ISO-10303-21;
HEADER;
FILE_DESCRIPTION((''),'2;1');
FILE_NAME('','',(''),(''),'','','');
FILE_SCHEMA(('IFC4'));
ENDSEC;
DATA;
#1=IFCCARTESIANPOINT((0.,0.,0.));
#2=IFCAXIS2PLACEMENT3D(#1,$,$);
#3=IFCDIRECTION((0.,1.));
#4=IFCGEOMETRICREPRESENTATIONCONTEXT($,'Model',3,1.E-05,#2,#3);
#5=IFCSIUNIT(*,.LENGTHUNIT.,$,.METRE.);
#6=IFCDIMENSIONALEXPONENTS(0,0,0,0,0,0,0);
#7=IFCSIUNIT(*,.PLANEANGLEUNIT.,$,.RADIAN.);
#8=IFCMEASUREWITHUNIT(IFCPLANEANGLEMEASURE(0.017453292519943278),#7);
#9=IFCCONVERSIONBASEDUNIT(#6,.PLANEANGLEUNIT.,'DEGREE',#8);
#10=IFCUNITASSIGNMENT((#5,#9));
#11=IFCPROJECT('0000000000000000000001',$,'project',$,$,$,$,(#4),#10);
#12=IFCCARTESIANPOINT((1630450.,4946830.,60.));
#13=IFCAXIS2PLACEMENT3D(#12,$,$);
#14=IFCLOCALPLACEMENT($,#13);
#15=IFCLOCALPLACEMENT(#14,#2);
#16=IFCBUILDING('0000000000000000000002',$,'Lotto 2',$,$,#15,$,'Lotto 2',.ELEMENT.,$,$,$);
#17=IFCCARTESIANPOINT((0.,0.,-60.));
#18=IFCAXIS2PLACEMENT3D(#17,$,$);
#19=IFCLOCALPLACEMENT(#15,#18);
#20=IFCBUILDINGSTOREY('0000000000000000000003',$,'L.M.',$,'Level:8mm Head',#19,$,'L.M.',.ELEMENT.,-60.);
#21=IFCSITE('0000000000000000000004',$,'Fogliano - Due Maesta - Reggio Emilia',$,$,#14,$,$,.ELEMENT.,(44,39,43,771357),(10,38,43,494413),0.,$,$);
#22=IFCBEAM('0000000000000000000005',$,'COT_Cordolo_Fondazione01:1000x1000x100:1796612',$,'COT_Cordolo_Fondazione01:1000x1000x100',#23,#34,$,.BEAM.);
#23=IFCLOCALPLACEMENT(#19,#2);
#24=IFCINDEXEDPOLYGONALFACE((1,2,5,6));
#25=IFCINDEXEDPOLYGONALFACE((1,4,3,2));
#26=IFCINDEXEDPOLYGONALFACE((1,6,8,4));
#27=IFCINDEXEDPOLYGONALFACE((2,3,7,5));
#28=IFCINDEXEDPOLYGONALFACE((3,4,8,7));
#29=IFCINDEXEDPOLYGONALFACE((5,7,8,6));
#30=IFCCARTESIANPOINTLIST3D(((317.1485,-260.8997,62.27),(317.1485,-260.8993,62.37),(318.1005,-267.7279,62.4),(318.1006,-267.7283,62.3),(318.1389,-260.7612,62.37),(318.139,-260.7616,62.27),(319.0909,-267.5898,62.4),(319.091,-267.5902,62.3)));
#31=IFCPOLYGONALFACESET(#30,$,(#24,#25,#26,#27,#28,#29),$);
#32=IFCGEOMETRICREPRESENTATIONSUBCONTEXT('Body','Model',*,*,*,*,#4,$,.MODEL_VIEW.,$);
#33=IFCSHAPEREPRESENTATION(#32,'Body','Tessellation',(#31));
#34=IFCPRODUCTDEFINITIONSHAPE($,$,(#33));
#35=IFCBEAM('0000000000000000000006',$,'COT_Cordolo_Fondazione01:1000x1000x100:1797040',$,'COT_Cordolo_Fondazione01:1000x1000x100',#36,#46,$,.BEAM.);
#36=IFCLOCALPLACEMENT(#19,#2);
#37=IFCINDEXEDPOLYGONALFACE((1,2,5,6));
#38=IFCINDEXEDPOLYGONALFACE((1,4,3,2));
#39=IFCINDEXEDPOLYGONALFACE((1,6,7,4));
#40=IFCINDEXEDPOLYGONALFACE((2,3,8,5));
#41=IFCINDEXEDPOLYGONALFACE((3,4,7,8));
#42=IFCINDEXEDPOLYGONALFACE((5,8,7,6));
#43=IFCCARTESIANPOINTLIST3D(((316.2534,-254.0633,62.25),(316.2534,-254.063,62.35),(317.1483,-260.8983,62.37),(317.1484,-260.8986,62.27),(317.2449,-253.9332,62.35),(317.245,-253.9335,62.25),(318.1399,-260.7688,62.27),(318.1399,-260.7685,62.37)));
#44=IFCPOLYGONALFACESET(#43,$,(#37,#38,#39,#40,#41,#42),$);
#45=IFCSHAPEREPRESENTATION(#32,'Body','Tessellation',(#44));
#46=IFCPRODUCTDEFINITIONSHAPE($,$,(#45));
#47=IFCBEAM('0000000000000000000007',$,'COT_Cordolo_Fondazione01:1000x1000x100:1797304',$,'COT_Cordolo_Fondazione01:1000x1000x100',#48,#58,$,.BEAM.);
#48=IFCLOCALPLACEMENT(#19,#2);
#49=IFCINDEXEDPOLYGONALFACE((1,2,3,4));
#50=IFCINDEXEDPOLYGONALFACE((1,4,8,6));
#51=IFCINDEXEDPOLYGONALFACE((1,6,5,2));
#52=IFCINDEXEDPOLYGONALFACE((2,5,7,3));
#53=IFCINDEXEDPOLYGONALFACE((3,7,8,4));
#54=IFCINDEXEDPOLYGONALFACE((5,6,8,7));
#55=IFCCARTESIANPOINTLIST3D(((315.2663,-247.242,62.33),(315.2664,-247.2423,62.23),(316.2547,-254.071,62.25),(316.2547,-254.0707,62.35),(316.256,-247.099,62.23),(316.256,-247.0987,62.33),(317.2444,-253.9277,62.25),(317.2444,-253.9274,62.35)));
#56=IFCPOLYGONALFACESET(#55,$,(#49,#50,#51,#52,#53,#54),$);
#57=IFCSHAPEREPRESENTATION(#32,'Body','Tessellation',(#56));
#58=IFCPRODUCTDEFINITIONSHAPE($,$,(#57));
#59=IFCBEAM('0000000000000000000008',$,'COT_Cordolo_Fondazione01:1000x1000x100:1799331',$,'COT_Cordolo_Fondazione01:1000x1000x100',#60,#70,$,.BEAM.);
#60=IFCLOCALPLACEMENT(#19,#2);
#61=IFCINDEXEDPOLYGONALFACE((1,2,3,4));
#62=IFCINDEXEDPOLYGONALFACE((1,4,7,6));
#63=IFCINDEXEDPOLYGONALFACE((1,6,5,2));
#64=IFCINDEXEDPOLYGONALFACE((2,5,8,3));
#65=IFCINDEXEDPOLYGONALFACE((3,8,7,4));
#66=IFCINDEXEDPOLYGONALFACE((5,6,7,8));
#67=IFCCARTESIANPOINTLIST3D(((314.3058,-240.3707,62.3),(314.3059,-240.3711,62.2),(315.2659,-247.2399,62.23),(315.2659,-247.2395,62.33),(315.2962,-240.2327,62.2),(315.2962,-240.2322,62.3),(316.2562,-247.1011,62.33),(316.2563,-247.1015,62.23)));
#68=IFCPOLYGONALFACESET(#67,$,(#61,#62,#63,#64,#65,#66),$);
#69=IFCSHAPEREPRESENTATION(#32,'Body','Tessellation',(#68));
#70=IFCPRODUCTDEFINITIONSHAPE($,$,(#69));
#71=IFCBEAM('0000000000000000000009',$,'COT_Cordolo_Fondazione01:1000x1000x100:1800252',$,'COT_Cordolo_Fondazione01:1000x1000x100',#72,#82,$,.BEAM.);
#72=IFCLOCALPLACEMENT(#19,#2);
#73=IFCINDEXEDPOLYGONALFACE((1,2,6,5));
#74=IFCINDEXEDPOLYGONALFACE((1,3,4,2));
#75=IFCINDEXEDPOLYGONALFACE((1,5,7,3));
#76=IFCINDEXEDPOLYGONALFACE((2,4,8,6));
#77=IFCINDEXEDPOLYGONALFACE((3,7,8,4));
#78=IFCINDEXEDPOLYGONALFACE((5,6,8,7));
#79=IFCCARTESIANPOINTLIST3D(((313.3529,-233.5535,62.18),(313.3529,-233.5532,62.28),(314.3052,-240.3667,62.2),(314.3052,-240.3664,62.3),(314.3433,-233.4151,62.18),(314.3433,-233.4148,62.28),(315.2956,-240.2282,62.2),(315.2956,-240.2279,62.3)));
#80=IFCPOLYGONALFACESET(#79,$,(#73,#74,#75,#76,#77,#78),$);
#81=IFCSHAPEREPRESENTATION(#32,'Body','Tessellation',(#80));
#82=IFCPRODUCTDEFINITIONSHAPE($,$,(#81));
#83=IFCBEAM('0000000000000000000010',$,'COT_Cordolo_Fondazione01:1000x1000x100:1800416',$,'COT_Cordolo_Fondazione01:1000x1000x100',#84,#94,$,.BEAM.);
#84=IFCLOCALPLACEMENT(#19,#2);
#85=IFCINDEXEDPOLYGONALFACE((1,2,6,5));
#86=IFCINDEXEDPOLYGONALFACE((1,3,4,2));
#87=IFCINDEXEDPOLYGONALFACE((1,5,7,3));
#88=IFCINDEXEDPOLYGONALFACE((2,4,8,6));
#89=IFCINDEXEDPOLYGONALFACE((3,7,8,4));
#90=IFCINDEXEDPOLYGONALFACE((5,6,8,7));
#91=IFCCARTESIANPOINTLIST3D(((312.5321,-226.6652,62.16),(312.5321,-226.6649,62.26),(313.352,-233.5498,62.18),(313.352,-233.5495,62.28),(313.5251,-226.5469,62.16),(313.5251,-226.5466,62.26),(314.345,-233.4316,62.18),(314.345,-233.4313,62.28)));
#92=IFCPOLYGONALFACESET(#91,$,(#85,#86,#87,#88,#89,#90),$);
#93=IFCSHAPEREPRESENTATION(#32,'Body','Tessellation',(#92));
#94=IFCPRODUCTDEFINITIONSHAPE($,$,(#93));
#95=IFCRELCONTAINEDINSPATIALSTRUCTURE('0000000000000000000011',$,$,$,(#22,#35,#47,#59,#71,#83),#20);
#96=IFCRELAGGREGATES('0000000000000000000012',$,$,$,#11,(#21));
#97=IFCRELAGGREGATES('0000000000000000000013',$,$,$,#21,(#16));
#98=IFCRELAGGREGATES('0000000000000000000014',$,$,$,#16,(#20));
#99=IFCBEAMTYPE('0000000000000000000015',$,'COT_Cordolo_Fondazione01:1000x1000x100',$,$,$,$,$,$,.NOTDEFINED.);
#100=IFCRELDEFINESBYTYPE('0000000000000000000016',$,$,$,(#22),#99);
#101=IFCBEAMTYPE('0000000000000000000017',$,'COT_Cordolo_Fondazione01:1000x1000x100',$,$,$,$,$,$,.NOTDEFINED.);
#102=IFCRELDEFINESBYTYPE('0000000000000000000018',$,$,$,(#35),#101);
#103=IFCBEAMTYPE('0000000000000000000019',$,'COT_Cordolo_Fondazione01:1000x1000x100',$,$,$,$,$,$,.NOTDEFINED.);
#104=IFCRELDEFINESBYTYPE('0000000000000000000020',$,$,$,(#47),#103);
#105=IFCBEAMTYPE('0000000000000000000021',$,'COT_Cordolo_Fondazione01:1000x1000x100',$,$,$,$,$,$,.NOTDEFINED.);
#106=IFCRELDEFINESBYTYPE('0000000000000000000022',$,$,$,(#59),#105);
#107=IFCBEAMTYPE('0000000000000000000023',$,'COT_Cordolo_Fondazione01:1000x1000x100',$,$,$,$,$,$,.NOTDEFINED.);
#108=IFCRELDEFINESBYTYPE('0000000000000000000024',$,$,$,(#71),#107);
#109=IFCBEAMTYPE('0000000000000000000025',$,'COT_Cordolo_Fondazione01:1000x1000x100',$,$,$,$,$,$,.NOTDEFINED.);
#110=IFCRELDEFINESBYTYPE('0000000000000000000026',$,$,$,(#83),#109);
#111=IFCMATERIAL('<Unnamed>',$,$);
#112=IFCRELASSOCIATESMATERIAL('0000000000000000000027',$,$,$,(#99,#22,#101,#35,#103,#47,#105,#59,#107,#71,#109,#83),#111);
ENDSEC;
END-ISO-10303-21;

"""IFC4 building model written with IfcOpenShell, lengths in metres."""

from ifc_helpers import new_model, entity, si_unit, converted_unit, direction, frame, origin, place, context, subcontext, project, spatial, indexed_curve, outline, extrude, source, transform, mapped, material, type_object, type_shapes, element, save


model = new_model("IFC4")

# Units and contexts
model_context = context("Model", 3, precision=1e-05, world=origin(), true_north=direction((0.0, 1.0)))
body_context = subcontext(model_context, "Body", "Model", "MODEL_VIEW")
ifc_project = project(units=[si_unit("LENGTHUNIT", "METRE"), converted_unit("PLANEANGLEUNIT", "DEGREE", entity("IfcPlaneAngleMeasure", 0.017453292519943278), si_unit("PLANEANGLEUNIT", "RADIAN"), dimensions=[0, 0, 0, 0, 0, 0, 0])], contexts=[model_context])

# Site, building, storey
site_placement = place(None, frame((1630450.0, 4946830.0, 60.0)))
site = spatial("IfcSite", under=ifc_project, at=site_placement, Name="Fogliano - Due Maesta - Reggio Emilia", CompositionType="ELEMENT", RefLatitude=(44, 39, 43, 771357), RefLongitude=(10, 38, 43, 494413), RefElevation=0.0)
building_placement = place(site_placement, origin())
building = spatial("IfcBuilding", under=site, at=building_placement, Name="Lotto 2", LongName="Lotto 2", CompositionType="ELEMENT")
storey_placement = place(building_placement, frame((0.0, 0.0, -60.0)))
storey = spatial("IfcBuildingStorey", under=building, at=storey_placement, Name="L.M.", ObjectType="Level:8mm Head", LongName="L.M.", CompositionType="ELEMENT", Elevation=-60.0)

# Beams
ifc_material_1 = material(Name="<Unnamed>")
beam_type_1 = type_object("IfcBeamType", Name="COT_Cordolo_Fondazione01:1000x1000x100", PredefinedType="NOTDEFINED", material=ifc_material_1)
shared_shape_1 = source(origin(), body_context, "Body", "SweptSolid", [
    extrude(outline(indexed_curve([(-3.4474, -0.5), (3.4474, -0.5), (3.4474, 0.5), (-3.4474, 0.5), (-3.4474, -0.5)], self_intersect=False)), frame((-0.0019, 0.0, -0.05), z_axis=(0.0, 0.0, 1.0), x_axis=(-1.0, 0.0, 0.0)), (0.0, 0.0, 1.0), 0.1),
])
type_shapes(beam_type_1, [shared_shape_1])
beam_1_placement = place(storey_placement, frame((318.1195, -264.2429, 62.335), z_axis=(-0.000601, 0.004312, 0.999991), x_axis=(-0.138084, 0.990411, -0.004354)))
element("IfcBeam", 1, at=beam_1_placement, inside=storey, type_object=beam_type_1, material=ifc_material_1, Name="COT_Cordolo_Fondazione01:1000x1000x100:1796612", ObjectType="COT_Cordolo_Fondazione01:1000x1000x100", PredefinedType="BEAM", context=body_context, shape_type="MappedRepresentation", body=[
    mapped(shared_shape_1, transform((0.0, 0.0, 0.0), scale=1.0)),
])
beam_type_2 = type_object("IfcBeamType", Name="COT_Cordolo_Fondazione01:1000x1000x100", PredefinedType="NOTDEFINED", material=ifc_material_1)
shared_shape_2 = source(origin(), body_context, "Body", "SweptSolid", [
    extrude(outline(indexed_curve([(-3.4468, -0.5), (3.4468, -0.5), (3.4468, 0.5), (-3.4468, 0.5), (-3.4468, -0.5)], self_intersect=False)), frame((-0.0019, 0.0, -0.05), z_axis=(0.0, 0.0, 1.0), x_axis=(-1.0, 0.0, 0.0)), (0.0, 0.0, 1.0), 0.1),
])
type_shapes(beam_type_2, [shared_shape_2])
beam_2_placement = place(storey_placement, frame((317.1964, -257.4141, 62.31), z_axis=(-0.000377, 0.002878, 0.999996), x_axis=(-0.129819, 0.991533, -0.002903)))
element("IfcBeam", 2, at=beam_2_placement, inside=storey, type_object=beam_type_2, material=ifc_material_1, Name="COT_Cordolo_Fondazione01:1000x1000x100:1797040", ObjectType="COT_Cordolo_Fondazione01:1000x1000x100", PredefinedType="BEAM", context=body_context, shape_type="MappedRepresentation", body=[
    mapped(shared_shape_2, transform((0.0, 0.0, 0.0), scale=1.0)),
])
beam_type_3 = type_object("IfcBeamType", Name="COT_Cordolo_Fondazione01:1000x1000x100", PredefinedType="NOTDEFINED", material=ifc_material_1)
shared_shape_3 = source(origin(), body_context, "Body", "SweptSolid", [
    extrude(outline(indexed_curve([(-3.4499, -0.5), (3.4499, -0.5), (3.4499, 0.5), (-3.4499, 0.5), (-3.4499, -0.5)], self_intersect=False)), frame((0.0001, 0.0, -0.05), z_axis=(0.0, 0.0, 1.0), x_axis=(-1.0, 0.0, 0.0)), (0.0, 0.0, 1.0), 0.1),
])
type_shapes(beam_type_3, [shared_shape_3])
beam_3_placement = place(storey_placement, frame((316.2554, -250.5849, 62.29), z_axis=(-0.000415, 0.002869, 0.999996), x_axis=(-0.143244, 0.989683, -0.002899)))
element("IfcBeam", 3, at=beam_3_placement, inside=storey, type_object=beam_type_3, material=ifc_material_1, Name="COT_Cordolo_Fondazione01:1000x1000x100:1797304", ObjectType="COT_Cordolo_Fondazione01:1000x1000x100", PredefinedType="BEAM", context=body_context, shape_type="MappedRepresentation", body=[
    mapped(shared_shape_3, transform((0.0, 0.0, 0.0), scale=1.0)),
])
beam_type_4 = type_object("IfcBeamType", Name="COT_Cordolo_Fondazione01:1000x1000x100", PredefinedType="NOTDEFINED", material=ifc_material_1)
shared_shape_4 = source(origin(), body_context, "Body", "SweptSolid", [
    extrude(outline(indexed_curve([(-3.4678, -0.5), (3.4678, -0.5), (3.4678, 0.5), (-3.4678, 0.5), (-3.4678, -0.5)], self_intersect=False)), frame((0.0003, 0.0, -0.05), z_axis=(0.0, 0.0, 1.0), x_axis=(-1.0, 0.0, 0.0)), (0.0, 0.0, 1.0), 0.1),
])
type_shapes(beam_type_4, [shared_shape_4])
beam_4_placement = place(storey_placement, frame((315.2811, -243.7364, 62.265), z_axis=(-0.000599, 0.004283, 0.999991), x_axis=(-0.138428, 0.990363, -0.004325)))
element("IfcBeam", 4, at=beam_4_placement, inside=storey, type_object=beam_type_4, material=ifc_material_1, Name="COT_Cordolo_Fondazione01:1000x1000x100:1799331", ObjectType="COT_Cordolo_Fondazione01:1000x1000x100", PredefinedType="BEAM", context=body_context, shape_type="MappedRepresentation", body=[
    mapped(shared_shape_4, transform((0.0, 0.0, 0.0), scale=1.0)),
])
beam_type_5 = type_object("IfcBeamType", Name="COT_Cordolo_Fondazione01:1000x1000x100", PredefinedType="NOTDEFINED", material=ifc_material_1)
shared_shape_5 = source(origin(), body_context, "Body", "SweptSolid", [
    extrude(outline(indexed_curve([(-3.4397, -0.5), (3.4397, -0.5), (3.4397, 0.5), (-3.4397, 0.5), (-3.4397, -0.5)], self_intersect=False)), frame((0.0003, 0.0, -0.05), z_axis=(0.0, 0.0, 1.0), x_axis=(-1.0, 0.0, 0.0)), (0.0, 0.0, 1.0), 0.1),
])
type_shapes(beam_type_5, [shared_shape_5])
beam_5_placement = place(storey_placement, frame((314.3243, -236.891, 62.24), z_axis=(-0.000402, 0.002879, 0.999996), x_axis=(-0.138428, 0.990368, -0.002907)))
element("IfcBeam", 5, at=beam_5_placement, inside=storey, type_object=beam_type_5, material=ifc_material_1, Name="COT_Cordolo_Fondazione01:1000x1000x100:1800252", ObjectType="COT_Cordolo_Fondazione01:1000x1000x100", PredefinedType="BEAM", context=body_context, shape_type="MappedRepresentation", body=[
    mapped(shared_shape_5, transform((0.0, 0.0, 0.0), scale=1.0)),
])
beam_type_6 = type_object("IfcBeamType", Name="COT_Cordolo_Fondazione01:1000x1000x100", PredefinedType="NOTDEFINED", material=ifc_material_1)
shared_shape_6 = source(origin(), body_context, "Body", "SweptSolid", [
    extrude(outline(indexed_curve([(-3.4667, -0.5), (3.4667, -0.5), (3.4667, 0.5), (-3.4667, 0.5), (-3.4667, -0.5)], self_intersect=False)), frame((0.0072, 0.0, -0.05), z_axis=(0.0, 0.0, 1.0), x_axis=(-1.0, 0.0, 0.0)), (0.0, 0.0, 1.0), 0.1),
])
type_shapes(beam_type_6, [shared_shape_6])
beam_6_placement = place(storey_placement, frame((313.4394, -230.0554, 62.22), z_axis=(-0.000342, 0.00287, 0.999996), x_axis=(-0.118253, 0.992979, -0.00289)))
element("IfcBeam", 6, at=beam_6_placement, inside=storey, type_object=beam_type_6, material=ifc_material_1, Name="COT_Cordolo_Fondazione01:1000x1000x100:1800416", ObjectType="COT_Cordolo_Fondazione01:1000x1000x100", PredefinedType="BEAM", context=body_context, shape_type="MappedRepresentation", body=[
    mapped(shared_shape_6, transform((0.0, 0.0, 0.0), scale=1.0)),
])

save(model, "model.ifc")
